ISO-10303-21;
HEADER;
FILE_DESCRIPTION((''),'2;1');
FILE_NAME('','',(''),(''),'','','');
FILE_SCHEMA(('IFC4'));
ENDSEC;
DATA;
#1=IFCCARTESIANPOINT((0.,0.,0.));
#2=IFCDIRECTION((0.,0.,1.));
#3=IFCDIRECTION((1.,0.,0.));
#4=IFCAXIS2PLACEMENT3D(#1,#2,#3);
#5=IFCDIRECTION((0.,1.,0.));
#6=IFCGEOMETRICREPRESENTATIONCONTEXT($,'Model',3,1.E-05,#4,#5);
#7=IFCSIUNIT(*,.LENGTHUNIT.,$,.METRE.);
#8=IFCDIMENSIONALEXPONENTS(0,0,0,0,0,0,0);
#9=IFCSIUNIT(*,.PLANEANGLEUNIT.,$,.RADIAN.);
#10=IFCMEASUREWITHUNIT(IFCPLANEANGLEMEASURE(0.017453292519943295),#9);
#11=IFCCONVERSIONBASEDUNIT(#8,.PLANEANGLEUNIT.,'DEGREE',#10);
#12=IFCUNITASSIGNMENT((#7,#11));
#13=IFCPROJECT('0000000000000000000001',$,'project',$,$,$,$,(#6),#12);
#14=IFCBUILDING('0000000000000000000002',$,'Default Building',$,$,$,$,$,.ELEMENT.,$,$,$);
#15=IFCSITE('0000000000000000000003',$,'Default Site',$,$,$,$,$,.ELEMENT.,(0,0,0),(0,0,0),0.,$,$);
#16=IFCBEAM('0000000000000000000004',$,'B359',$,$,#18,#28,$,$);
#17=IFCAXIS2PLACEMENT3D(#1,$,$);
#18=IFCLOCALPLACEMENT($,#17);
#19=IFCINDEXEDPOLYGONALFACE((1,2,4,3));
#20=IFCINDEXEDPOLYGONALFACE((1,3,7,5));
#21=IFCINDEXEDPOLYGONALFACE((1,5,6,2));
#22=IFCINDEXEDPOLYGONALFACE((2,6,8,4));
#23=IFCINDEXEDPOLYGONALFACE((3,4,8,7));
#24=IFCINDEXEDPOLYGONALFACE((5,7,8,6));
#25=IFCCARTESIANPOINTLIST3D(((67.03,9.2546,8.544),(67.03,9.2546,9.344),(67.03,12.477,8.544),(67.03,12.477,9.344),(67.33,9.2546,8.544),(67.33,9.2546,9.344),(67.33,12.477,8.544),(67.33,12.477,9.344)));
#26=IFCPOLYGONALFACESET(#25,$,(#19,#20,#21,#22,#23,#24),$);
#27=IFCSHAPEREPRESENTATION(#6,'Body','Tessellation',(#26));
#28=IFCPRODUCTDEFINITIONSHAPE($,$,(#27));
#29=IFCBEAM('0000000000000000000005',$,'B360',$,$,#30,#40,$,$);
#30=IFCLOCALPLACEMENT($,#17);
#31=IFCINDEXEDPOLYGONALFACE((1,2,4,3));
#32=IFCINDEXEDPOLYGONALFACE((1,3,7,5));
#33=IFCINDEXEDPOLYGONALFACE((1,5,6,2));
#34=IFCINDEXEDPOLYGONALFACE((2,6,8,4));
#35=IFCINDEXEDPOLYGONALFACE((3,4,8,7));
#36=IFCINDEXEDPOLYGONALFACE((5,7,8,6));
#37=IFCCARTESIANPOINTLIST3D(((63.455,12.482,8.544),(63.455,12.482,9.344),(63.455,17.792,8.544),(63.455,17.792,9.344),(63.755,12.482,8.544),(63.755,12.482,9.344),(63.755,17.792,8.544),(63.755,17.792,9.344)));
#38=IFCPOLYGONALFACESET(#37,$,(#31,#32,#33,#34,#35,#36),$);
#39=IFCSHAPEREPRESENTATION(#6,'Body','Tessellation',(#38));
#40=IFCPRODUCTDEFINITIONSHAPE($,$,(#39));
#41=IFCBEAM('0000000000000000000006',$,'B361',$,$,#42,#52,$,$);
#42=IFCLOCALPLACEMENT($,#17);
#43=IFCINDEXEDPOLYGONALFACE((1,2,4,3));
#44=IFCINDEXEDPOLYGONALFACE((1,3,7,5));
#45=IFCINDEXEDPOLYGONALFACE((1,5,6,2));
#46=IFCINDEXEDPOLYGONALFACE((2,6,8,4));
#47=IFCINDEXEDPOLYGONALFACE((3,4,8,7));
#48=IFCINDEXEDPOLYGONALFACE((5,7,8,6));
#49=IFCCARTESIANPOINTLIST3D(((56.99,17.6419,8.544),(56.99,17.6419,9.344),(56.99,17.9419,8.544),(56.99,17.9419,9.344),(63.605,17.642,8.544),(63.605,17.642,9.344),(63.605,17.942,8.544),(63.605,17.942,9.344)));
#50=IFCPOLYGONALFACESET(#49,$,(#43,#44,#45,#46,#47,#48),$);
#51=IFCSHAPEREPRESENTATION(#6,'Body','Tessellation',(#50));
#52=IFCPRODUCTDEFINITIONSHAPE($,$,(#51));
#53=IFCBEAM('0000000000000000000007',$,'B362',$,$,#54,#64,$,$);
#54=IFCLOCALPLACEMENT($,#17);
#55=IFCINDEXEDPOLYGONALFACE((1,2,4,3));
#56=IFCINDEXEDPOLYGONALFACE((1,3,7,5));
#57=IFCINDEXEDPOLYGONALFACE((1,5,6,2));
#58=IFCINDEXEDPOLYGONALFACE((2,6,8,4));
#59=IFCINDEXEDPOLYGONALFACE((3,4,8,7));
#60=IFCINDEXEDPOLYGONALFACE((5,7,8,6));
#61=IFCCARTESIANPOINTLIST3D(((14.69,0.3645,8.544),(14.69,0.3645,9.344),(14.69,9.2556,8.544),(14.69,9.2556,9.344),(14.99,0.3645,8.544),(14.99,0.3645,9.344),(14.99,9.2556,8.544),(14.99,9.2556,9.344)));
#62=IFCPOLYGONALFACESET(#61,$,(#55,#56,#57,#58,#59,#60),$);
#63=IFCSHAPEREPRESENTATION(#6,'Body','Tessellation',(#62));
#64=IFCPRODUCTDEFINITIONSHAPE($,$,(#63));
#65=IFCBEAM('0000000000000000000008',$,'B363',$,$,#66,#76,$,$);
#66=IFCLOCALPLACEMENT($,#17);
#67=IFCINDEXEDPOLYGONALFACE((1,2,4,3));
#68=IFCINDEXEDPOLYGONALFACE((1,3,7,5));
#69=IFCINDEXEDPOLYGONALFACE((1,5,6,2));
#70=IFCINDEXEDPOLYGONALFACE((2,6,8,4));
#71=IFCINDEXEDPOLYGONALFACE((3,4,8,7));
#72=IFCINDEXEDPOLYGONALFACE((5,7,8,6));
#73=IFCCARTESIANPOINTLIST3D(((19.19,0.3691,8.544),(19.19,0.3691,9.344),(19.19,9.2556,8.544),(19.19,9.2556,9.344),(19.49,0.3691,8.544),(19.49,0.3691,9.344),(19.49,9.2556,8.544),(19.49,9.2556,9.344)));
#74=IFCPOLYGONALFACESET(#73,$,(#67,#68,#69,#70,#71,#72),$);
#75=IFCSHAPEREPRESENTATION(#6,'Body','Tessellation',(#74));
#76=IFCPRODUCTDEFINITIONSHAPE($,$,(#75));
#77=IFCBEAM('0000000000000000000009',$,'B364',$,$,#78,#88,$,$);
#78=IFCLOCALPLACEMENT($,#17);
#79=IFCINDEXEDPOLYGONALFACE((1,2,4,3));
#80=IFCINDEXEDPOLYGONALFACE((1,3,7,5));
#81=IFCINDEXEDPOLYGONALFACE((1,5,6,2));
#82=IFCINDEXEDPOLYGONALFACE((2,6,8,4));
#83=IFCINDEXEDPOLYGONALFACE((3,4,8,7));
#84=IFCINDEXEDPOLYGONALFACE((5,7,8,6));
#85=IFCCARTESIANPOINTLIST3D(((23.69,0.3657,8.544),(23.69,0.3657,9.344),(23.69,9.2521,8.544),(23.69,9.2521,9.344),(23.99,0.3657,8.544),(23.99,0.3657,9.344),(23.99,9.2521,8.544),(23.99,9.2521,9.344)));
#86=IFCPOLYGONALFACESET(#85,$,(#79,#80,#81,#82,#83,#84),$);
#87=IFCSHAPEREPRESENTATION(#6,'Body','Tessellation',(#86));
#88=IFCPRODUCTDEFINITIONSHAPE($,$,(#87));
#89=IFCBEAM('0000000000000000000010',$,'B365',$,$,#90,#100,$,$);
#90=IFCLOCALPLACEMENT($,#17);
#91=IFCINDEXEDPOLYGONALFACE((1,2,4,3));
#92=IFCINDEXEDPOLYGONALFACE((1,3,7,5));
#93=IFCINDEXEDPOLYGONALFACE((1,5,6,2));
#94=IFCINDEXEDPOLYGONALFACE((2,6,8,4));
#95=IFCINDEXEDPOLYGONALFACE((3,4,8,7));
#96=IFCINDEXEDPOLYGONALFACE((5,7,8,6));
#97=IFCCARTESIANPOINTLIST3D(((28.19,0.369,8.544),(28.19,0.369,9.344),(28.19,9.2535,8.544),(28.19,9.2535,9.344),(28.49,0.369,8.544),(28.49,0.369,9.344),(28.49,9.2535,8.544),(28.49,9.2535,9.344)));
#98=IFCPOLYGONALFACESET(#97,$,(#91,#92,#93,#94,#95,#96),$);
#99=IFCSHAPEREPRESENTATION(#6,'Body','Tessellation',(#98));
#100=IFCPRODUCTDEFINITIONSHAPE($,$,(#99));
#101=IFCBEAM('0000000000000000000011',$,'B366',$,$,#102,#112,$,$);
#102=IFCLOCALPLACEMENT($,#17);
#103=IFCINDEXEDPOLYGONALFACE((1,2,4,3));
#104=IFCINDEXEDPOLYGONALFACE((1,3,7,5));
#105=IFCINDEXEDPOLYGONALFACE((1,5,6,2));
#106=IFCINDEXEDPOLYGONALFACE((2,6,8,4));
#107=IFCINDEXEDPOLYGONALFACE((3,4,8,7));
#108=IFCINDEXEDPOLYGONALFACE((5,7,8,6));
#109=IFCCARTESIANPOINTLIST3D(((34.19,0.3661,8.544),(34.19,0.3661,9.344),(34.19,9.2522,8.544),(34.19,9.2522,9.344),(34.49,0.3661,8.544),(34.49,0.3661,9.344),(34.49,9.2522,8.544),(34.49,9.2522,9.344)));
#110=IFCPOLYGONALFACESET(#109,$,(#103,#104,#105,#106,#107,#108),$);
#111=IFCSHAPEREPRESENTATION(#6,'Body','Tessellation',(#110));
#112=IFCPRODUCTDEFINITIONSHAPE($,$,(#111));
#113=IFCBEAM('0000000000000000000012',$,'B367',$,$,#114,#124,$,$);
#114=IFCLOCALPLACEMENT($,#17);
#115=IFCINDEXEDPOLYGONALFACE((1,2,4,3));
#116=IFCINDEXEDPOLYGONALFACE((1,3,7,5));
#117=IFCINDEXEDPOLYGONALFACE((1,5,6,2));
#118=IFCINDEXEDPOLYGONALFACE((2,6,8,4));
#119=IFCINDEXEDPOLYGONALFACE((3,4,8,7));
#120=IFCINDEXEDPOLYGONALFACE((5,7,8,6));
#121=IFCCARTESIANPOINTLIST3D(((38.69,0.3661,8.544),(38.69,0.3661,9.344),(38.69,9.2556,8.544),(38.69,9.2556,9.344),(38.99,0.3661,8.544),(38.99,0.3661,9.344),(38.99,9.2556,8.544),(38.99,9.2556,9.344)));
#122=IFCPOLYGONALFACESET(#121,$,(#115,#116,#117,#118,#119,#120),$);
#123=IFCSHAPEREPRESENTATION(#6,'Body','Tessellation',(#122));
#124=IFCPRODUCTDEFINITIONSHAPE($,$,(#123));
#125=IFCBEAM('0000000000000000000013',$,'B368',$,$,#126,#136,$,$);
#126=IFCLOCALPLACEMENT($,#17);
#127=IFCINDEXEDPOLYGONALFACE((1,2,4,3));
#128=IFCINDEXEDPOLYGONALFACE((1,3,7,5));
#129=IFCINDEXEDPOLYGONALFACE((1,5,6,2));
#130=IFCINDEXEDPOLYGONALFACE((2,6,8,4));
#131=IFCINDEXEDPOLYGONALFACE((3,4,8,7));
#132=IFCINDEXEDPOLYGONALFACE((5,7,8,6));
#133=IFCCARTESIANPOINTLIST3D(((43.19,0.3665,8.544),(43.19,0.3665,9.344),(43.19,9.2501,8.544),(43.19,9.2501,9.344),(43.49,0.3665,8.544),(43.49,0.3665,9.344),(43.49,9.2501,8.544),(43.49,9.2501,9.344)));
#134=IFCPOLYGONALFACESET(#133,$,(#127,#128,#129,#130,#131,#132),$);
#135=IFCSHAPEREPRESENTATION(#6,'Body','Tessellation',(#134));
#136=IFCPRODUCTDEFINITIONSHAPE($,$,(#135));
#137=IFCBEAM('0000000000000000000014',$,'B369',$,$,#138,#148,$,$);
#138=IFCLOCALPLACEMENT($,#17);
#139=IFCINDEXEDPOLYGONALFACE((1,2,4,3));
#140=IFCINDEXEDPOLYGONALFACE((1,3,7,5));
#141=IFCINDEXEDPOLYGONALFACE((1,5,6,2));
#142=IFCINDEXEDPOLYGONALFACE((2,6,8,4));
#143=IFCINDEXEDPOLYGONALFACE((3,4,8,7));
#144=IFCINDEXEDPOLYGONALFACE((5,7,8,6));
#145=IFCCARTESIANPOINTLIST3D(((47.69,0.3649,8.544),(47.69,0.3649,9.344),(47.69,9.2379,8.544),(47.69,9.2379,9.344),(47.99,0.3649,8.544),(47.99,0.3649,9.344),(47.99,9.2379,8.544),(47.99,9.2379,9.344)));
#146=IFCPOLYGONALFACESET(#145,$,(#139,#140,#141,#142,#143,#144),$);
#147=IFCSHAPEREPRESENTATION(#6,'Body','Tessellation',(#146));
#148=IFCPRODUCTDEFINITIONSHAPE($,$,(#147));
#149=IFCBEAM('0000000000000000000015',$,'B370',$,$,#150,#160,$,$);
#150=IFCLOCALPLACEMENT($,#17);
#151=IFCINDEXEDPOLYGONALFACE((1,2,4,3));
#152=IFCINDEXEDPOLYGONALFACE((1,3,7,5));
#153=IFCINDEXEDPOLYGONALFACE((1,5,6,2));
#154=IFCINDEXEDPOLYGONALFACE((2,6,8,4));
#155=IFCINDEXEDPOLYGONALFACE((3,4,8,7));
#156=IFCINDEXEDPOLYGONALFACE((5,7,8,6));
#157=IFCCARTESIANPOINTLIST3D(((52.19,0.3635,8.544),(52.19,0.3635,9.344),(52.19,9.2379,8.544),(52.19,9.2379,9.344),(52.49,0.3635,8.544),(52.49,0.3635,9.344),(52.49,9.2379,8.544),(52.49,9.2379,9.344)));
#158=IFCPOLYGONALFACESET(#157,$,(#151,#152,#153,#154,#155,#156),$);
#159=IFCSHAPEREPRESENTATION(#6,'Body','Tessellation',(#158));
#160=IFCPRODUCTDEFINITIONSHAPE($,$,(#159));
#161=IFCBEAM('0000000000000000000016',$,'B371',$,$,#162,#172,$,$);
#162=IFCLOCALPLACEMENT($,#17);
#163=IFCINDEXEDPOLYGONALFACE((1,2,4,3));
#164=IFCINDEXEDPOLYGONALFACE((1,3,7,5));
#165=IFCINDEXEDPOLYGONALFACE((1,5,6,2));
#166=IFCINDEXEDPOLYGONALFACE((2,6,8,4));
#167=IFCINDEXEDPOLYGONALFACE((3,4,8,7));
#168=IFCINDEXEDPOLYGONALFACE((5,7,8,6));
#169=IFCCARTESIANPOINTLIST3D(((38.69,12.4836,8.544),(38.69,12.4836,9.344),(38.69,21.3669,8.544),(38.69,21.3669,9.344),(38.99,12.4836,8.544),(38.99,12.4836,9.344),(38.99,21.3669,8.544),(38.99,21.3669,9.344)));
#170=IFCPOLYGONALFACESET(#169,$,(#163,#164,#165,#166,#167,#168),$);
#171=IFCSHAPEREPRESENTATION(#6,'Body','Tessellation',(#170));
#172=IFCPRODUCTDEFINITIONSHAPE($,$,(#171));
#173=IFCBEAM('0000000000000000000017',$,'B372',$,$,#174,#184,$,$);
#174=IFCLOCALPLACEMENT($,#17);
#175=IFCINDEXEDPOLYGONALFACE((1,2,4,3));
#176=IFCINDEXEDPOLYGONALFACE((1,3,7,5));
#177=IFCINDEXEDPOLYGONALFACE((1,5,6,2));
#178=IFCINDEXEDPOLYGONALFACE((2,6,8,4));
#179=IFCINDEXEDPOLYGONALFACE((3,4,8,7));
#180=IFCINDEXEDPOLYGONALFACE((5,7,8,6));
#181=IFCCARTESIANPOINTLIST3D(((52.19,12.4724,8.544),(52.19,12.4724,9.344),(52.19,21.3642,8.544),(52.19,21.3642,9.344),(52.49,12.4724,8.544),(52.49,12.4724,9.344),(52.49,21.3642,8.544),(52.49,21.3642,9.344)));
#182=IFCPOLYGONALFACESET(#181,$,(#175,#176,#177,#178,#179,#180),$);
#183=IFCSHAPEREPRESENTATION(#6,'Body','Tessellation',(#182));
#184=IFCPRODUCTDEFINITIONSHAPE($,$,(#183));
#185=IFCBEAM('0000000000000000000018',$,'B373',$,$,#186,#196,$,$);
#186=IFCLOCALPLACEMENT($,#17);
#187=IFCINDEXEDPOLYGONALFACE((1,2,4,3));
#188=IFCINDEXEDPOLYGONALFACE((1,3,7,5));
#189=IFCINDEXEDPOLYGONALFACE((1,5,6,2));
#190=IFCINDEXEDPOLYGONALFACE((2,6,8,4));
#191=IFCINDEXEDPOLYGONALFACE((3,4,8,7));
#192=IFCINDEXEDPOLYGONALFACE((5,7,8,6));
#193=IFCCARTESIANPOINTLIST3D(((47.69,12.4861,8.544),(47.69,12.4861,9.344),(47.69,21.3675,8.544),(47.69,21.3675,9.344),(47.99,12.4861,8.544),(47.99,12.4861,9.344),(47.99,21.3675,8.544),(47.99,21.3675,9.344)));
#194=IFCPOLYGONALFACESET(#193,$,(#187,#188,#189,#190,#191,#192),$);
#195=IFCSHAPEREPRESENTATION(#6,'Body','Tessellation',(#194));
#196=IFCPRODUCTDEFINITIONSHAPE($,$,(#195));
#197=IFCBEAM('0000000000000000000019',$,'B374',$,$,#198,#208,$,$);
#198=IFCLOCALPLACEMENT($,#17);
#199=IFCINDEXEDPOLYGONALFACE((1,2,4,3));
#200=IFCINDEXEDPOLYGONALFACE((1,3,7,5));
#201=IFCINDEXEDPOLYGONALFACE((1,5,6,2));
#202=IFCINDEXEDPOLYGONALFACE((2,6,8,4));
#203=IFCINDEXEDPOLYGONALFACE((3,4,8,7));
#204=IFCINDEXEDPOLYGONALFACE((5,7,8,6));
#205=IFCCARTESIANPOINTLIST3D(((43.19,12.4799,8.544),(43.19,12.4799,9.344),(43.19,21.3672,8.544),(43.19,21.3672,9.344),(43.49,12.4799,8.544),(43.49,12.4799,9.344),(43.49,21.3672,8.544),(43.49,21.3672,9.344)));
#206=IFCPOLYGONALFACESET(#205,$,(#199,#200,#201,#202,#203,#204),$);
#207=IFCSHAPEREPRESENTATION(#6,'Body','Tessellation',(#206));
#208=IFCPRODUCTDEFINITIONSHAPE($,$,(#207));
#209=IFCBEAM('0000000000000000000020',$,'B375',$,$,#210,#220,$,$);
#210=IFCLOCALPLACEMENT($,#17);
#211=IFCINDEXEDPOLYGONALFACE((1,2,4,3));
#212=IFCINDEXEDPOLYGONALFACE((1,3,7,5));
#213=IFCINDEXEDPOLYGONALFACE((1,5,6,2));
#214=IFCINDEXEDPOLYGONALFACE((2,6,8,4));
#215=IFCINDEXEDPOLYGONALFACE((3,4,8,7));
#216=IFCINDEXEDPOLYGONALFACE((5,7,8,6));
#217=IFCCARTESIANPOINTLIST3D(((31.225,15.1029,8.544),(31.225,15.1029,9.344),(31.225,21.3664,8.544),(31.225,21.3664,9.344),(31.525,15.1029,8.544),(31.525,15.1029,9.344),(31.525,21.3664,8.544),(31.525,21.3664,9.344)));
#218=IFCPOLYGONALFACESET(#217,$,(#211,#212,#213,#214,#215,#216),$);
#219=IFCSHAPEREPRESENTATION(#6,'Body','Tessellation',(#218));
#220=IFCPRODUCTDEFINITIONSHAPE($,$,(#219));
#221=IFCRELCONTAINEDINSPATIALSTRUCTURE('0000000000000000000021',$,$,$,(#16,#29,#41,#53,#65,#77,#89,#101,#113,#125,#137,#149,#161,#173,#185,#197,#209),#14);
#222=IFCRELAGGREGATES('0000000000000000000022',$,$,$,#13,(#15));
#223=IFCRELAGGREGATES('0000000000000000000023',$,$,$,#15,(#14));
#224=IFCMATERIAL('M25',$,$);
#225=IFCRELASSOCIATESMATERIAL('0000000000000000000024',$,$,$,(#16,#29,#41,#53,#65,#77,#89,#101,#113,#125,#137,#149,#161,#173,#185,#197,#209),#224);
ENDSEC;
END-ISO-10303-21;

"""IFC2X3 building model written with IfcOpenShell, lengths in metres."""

from ifc_helpers import new_model, entity, si_unit, converted_unit, direction, frame, frame_2d, origin_with_axes, place, context, project, spatial, rectangle, extrude, material, element, save


model = new_model("IFC2X3")

# Units and contexts
model_context = context("Model", 3, precision=1e-05, world=origin_with_axes(), true_north=direction((0.0, 1.0, 0.0)))
ifc_project = project(units=[si_unit("LENGTHUNIT", "METRE"), converted_unit("PLANEANGLEUNIT", "DEGREE", entity("IfcPlaneAngleMeasure", 0.017453292519943295), si_unit("PLANEANGLEUNIT", "RADIAN"), dimensions=[0, 0, 0, 0, 0, 0, 0])], contexts=[model_context])

# Site, building
site = spatial("IfcSite", under=ifc_project, Name="Default Site", CompositionType="ELEMENT", RefLatitude=(0, 0, 0), RefLongitude=(0, 0, 0), RefElevation=0.0)
building = spatial("IfcBuilding", under=site, Name="Default Building", CompositionType="ELEMENT")

# Beams
ifc_material = material(Name="M25")
placement = place(None, origin_with_axes())
element("IfcBeam", 1, at=placement, inside=building, material=ifc_material, Name="B359", context=model_context, shape_type="SweptSolid", body=[
    extrude(rectangle(XDim=0.3, YDim=0.8, at=frame_2d((0.0, 0.0), x_axis=(0.0, 1.0, 0.0))), frame((67.18, 9.2546, 8.944), z_axis=(0.0, 1.0, 0.0), x_axis=(0.0, 0.0, -1.0)), (0.0, 0.0, 1.0), 3.2224),
])
element("IfcBeam", 2, at=placement, inside=building, material=ifc_material, Name="B360", context=model_context, shape_type="SweptSolid", body=[
    extrude(rectangle(XDim=0.3, YDim=0.8, at=frame_2d((0.0, 0.0), x_axis=(0.0, 1.0, 0.0))), frame((63.605, 12.482, 8.944), z_axis=(0.0, 1.0, 0.0), x_axis=(0.0, 0.0, -1.0)), (0.0, 0.0, 1.0), 5.3101),
])
element("IfcBeam", 3, at=placement, inside=building, material=ifc_material, Name="B361", context=model_context, shape_type="SweptSolid", body=[
    extrude(rectangle(XDim=0.3, YDim=0.8, at=frame_2d((0.0, 0.0), x_axis=(0.0, 1.0, 0.0))), frame((56.99, 17.7919, 8.944), z_axis=(1.0, 0.00002, 0.0), x_axis=(0.0, 0.0, -1.0)), (0.0, 0.0, 1.0), 6.615),
])
element("IfcBeam", 4, at=placement, inside=building, material=ifc_material, Name="B362", context=model_context, shape_type="SweptSolid", body=[
    extrude(rectangle(XDim=0.3, YDim=0.8, at=frame_2d((0.0, 0.0), x_axis=(0.0, 1.0, 0.0))), frame((14.84, 0.3645, 8.944), z_axis=(0.0, 1.0, 0.0), x_axis=(0.0, 0.0, -1.0)), (0.0, 0.0, 1.0), 8.891),
])
element("IfcBeam", 5, at=placement, inside=building, material=ifc_material, Name="B363", context=model_context, shape_type="SweptSolid", body=[
    extrude(rectangle(XDim=0.3, YDim=0.8, at=frame_2d((0.0, 0.0), x_axis=(0.0, 1.0, 0.0))), frame((19.34, 0.3691, 8.944), z_axis=(0.0, 1.0, 0.0), x_axis=(0.0, 0.0, -1.0)), (0.0, 0.0, 1.0), 8.8865),
])
element("IfcBeam", 6, at=placement, inside=building, material=ifc_material, Name="B364", context=model_context, shape_type="SweptSolid", body=[
    extrude(rectangle(XDim=0.3, YDim=0.8, at=frame_2d((0.0, 0.0), x_axis=(0.0, 1.0, 0.0))), frame((23.84, 0.3657, 8.944), z_axis=(0.0, 1.0, 0.0), x_axis=(0.0, 0.0, -1.0)), (0.0, 0.0, 1.0), 8.8864),
])
element("IfcBeam", 7, at=placement, inside=building, material=ifc_material, Name="B365", context=model_context, shape_type="SweptSolid", body=[
    extrude(rectangle(XDim=0.3, YDim=0.8, at=frame_2d((0.0, 0.0), x_axis=(0.0, 1.0, 0.0))), frame((28.34, 0.369, 8.944), z_axis=(0.0, 1.0, 0.0), x_axis=(0.0, 0.0, -1.0)), (0.0, 0.0, 1.0), 8.8845),
])
element("IfcBeam", 8, at=placement, inside=building, material=ifc_material, Name="B366", context=model_context, shape_type="SweptSolid", body=[
    extrude(rectangle(XDim=0.3, YDim=0.8, at=frame_2d((0.0, 0.0), x_axis=(0.0, 1.0, 0.0))), frame((34.34, 0.3661, 8.944), z_axis=(0.0, 1.0, 0.0), x_axis=(0.0, 0.0, -1.0)), (0.0, 0.0, 1.0), 8.8861),
])
element("IfcBeam", 9, at=placement, inside=building, material=ifc_material, Name="B367", context=model_context, shape_type="SweptSolid", body=[
    extrude(rectangle(XDim=0.3, YDim=0.8, at=frame_2d((0.0, 0.0), x_axis=(0.0, 1.0, 0.0))), frame((38.84, 0.3661, 8.944), z_axis=(0.0, 1.0, 0.0), x_axis=(0.0, 0.0, -1.0)), (0.0, 0.0, 1.0), 8.8895),
])
element("IfcBeam", 10, at=placement, inside=building, material=ifc_material, Name="B368", context=model_context, shape_type="SweptSolid", body=[
    extrude(rectangle(XDim=0.3, YDim=0.8, at=frame_2d((0.0, 0.0), x_axis=(0.0, 1.0, 0.0))), frame((43.34, 0.3665, 8.944), z_axis=(0.0, 1.0, 0.0), x_axis=(0.0, 0.0, -1.0)), (0.0, 0.0, 1.0), 8.8836),
])
element("IfcBeam", 11, at=placement, inside=building, material=ifc_material, Name="B369", context=model_context, shape_type="SweptSolid", body=[
    extrude(rectangle(XDim=0.3, YDim=0.8, at=frame_2d((0.0, 0.0), x_axis=(0.0, 1.0, 0.0))), frame((47.84, 0.3649, 8.944), z_axis=(0.0, 1.0, 0.0), x_axis=(0.0, 0.0, -1.0)), (0.0, 0.0, 1.0), 8.873),
])
element("IfcBeam", 12, at=placement, inside=building, material=ifc_material, Name="B370", context=model_context, shape_type="SweptSolid", body=[
    extrude(rectangle(XDim=0.3, YDim=0.8, at=frame_2d((0.0, 0.0), x_axis=(0.0, 1.0, 0.0))), frame((52.34, 0.3635, 8.944), z_axis=(0.0, 1.0, 0.0), x_axis=(0.0, 0.0, -1.0)), (0.0, 0.0, 1.0), 8.8744),
])
element("IfcBeam", 13, at=placement, inside=building, material=ifc_material, Name="B371", context=model_context, shape_type="SweptSolid", body=[
    extrude(rectangle(XDim=0.3, YDim=0.8, at=frame_2d((0.0, 0.0), x_axis=(0.0, 1.0, 0.0))), frame((38.84, 21.3669, 8.944), z_axis=(0.0, -1.0, 0.0), x_axis=(0.0, 0.0, -1.0)), (0.0, 0.0, 1.0), 8.8833),
])
element("IfcBeam", 14, at=placement, inside=building, material=ifc_material, Name="B372", context=model_context, shape_type="SweptSolid", body=[
    extrude(rectangle(XDim=0.3, YDim=0.8, at=frame_2d((0.0, 0.0), x_axis=(0.0, 1.0, 0.0))), frame((52.34, 12.4724, 8.944), z_axis=(0.0, 1.0, 0.0), x_axis=(0.0, 0.0, -1.0)), (0.0, 0.0, 1.0), 8.8918),
])
element("IfcBeam", 15, at=placement, inside=building, material=ifc_material, Name="B373", context=model_context, shape_type="SweptSolid", body=[
    extrude(rectangle(XDim=0.3, YDim=0.8, at=frame_2d((0.0, 0.0), x_axis=(0.0, 1.0, 0.0))), frame((47.84, 12.4861, 8.944), z_axis=(0.0, 1.0, 0.0), x_axis=(0.0, 0.0, -1.0)), (0.0, 0.0, 1.0), 8.8814),
])
element("IfcBeam", 16, at=placement, inside=building, material=ifc_material, Name="B374", context=model_context, shape_type="SweptSolid", body=[
    extrude(rectangle(XDim=0.3, YDim=0.8, at=frame_2d((0.0, 0.0), x_axis=(0.0, 1.0, 0.0))), frame((43.34, 21.3672, 8.944), z_axis=(0.0, -1.0, 0.0), x_axis=(0.0, 0.0, -1.0)), (0.0, 0.0, 1.0), 8.8873),
])
element("IfcBeam", 17, at=placement, inside=building, material=ifc_material, Name="B375", context=model_context, shape_type="SweptSolid", body=[
    extrude(rectangle(XDim=0.3, YDim=0.8, at=frame_2d((0.0, 0.0), x_axis=(0.0, 1.0, 0.0))), frame((31.375, 21.3664, 8.944), z_axis=(0.0, -1.0, 0.0), x_axis=(0.0, 0.0, -1.0)), (0.0, 0.0, 1.0), 6.2635),
])

save(model, "model.ifc")
